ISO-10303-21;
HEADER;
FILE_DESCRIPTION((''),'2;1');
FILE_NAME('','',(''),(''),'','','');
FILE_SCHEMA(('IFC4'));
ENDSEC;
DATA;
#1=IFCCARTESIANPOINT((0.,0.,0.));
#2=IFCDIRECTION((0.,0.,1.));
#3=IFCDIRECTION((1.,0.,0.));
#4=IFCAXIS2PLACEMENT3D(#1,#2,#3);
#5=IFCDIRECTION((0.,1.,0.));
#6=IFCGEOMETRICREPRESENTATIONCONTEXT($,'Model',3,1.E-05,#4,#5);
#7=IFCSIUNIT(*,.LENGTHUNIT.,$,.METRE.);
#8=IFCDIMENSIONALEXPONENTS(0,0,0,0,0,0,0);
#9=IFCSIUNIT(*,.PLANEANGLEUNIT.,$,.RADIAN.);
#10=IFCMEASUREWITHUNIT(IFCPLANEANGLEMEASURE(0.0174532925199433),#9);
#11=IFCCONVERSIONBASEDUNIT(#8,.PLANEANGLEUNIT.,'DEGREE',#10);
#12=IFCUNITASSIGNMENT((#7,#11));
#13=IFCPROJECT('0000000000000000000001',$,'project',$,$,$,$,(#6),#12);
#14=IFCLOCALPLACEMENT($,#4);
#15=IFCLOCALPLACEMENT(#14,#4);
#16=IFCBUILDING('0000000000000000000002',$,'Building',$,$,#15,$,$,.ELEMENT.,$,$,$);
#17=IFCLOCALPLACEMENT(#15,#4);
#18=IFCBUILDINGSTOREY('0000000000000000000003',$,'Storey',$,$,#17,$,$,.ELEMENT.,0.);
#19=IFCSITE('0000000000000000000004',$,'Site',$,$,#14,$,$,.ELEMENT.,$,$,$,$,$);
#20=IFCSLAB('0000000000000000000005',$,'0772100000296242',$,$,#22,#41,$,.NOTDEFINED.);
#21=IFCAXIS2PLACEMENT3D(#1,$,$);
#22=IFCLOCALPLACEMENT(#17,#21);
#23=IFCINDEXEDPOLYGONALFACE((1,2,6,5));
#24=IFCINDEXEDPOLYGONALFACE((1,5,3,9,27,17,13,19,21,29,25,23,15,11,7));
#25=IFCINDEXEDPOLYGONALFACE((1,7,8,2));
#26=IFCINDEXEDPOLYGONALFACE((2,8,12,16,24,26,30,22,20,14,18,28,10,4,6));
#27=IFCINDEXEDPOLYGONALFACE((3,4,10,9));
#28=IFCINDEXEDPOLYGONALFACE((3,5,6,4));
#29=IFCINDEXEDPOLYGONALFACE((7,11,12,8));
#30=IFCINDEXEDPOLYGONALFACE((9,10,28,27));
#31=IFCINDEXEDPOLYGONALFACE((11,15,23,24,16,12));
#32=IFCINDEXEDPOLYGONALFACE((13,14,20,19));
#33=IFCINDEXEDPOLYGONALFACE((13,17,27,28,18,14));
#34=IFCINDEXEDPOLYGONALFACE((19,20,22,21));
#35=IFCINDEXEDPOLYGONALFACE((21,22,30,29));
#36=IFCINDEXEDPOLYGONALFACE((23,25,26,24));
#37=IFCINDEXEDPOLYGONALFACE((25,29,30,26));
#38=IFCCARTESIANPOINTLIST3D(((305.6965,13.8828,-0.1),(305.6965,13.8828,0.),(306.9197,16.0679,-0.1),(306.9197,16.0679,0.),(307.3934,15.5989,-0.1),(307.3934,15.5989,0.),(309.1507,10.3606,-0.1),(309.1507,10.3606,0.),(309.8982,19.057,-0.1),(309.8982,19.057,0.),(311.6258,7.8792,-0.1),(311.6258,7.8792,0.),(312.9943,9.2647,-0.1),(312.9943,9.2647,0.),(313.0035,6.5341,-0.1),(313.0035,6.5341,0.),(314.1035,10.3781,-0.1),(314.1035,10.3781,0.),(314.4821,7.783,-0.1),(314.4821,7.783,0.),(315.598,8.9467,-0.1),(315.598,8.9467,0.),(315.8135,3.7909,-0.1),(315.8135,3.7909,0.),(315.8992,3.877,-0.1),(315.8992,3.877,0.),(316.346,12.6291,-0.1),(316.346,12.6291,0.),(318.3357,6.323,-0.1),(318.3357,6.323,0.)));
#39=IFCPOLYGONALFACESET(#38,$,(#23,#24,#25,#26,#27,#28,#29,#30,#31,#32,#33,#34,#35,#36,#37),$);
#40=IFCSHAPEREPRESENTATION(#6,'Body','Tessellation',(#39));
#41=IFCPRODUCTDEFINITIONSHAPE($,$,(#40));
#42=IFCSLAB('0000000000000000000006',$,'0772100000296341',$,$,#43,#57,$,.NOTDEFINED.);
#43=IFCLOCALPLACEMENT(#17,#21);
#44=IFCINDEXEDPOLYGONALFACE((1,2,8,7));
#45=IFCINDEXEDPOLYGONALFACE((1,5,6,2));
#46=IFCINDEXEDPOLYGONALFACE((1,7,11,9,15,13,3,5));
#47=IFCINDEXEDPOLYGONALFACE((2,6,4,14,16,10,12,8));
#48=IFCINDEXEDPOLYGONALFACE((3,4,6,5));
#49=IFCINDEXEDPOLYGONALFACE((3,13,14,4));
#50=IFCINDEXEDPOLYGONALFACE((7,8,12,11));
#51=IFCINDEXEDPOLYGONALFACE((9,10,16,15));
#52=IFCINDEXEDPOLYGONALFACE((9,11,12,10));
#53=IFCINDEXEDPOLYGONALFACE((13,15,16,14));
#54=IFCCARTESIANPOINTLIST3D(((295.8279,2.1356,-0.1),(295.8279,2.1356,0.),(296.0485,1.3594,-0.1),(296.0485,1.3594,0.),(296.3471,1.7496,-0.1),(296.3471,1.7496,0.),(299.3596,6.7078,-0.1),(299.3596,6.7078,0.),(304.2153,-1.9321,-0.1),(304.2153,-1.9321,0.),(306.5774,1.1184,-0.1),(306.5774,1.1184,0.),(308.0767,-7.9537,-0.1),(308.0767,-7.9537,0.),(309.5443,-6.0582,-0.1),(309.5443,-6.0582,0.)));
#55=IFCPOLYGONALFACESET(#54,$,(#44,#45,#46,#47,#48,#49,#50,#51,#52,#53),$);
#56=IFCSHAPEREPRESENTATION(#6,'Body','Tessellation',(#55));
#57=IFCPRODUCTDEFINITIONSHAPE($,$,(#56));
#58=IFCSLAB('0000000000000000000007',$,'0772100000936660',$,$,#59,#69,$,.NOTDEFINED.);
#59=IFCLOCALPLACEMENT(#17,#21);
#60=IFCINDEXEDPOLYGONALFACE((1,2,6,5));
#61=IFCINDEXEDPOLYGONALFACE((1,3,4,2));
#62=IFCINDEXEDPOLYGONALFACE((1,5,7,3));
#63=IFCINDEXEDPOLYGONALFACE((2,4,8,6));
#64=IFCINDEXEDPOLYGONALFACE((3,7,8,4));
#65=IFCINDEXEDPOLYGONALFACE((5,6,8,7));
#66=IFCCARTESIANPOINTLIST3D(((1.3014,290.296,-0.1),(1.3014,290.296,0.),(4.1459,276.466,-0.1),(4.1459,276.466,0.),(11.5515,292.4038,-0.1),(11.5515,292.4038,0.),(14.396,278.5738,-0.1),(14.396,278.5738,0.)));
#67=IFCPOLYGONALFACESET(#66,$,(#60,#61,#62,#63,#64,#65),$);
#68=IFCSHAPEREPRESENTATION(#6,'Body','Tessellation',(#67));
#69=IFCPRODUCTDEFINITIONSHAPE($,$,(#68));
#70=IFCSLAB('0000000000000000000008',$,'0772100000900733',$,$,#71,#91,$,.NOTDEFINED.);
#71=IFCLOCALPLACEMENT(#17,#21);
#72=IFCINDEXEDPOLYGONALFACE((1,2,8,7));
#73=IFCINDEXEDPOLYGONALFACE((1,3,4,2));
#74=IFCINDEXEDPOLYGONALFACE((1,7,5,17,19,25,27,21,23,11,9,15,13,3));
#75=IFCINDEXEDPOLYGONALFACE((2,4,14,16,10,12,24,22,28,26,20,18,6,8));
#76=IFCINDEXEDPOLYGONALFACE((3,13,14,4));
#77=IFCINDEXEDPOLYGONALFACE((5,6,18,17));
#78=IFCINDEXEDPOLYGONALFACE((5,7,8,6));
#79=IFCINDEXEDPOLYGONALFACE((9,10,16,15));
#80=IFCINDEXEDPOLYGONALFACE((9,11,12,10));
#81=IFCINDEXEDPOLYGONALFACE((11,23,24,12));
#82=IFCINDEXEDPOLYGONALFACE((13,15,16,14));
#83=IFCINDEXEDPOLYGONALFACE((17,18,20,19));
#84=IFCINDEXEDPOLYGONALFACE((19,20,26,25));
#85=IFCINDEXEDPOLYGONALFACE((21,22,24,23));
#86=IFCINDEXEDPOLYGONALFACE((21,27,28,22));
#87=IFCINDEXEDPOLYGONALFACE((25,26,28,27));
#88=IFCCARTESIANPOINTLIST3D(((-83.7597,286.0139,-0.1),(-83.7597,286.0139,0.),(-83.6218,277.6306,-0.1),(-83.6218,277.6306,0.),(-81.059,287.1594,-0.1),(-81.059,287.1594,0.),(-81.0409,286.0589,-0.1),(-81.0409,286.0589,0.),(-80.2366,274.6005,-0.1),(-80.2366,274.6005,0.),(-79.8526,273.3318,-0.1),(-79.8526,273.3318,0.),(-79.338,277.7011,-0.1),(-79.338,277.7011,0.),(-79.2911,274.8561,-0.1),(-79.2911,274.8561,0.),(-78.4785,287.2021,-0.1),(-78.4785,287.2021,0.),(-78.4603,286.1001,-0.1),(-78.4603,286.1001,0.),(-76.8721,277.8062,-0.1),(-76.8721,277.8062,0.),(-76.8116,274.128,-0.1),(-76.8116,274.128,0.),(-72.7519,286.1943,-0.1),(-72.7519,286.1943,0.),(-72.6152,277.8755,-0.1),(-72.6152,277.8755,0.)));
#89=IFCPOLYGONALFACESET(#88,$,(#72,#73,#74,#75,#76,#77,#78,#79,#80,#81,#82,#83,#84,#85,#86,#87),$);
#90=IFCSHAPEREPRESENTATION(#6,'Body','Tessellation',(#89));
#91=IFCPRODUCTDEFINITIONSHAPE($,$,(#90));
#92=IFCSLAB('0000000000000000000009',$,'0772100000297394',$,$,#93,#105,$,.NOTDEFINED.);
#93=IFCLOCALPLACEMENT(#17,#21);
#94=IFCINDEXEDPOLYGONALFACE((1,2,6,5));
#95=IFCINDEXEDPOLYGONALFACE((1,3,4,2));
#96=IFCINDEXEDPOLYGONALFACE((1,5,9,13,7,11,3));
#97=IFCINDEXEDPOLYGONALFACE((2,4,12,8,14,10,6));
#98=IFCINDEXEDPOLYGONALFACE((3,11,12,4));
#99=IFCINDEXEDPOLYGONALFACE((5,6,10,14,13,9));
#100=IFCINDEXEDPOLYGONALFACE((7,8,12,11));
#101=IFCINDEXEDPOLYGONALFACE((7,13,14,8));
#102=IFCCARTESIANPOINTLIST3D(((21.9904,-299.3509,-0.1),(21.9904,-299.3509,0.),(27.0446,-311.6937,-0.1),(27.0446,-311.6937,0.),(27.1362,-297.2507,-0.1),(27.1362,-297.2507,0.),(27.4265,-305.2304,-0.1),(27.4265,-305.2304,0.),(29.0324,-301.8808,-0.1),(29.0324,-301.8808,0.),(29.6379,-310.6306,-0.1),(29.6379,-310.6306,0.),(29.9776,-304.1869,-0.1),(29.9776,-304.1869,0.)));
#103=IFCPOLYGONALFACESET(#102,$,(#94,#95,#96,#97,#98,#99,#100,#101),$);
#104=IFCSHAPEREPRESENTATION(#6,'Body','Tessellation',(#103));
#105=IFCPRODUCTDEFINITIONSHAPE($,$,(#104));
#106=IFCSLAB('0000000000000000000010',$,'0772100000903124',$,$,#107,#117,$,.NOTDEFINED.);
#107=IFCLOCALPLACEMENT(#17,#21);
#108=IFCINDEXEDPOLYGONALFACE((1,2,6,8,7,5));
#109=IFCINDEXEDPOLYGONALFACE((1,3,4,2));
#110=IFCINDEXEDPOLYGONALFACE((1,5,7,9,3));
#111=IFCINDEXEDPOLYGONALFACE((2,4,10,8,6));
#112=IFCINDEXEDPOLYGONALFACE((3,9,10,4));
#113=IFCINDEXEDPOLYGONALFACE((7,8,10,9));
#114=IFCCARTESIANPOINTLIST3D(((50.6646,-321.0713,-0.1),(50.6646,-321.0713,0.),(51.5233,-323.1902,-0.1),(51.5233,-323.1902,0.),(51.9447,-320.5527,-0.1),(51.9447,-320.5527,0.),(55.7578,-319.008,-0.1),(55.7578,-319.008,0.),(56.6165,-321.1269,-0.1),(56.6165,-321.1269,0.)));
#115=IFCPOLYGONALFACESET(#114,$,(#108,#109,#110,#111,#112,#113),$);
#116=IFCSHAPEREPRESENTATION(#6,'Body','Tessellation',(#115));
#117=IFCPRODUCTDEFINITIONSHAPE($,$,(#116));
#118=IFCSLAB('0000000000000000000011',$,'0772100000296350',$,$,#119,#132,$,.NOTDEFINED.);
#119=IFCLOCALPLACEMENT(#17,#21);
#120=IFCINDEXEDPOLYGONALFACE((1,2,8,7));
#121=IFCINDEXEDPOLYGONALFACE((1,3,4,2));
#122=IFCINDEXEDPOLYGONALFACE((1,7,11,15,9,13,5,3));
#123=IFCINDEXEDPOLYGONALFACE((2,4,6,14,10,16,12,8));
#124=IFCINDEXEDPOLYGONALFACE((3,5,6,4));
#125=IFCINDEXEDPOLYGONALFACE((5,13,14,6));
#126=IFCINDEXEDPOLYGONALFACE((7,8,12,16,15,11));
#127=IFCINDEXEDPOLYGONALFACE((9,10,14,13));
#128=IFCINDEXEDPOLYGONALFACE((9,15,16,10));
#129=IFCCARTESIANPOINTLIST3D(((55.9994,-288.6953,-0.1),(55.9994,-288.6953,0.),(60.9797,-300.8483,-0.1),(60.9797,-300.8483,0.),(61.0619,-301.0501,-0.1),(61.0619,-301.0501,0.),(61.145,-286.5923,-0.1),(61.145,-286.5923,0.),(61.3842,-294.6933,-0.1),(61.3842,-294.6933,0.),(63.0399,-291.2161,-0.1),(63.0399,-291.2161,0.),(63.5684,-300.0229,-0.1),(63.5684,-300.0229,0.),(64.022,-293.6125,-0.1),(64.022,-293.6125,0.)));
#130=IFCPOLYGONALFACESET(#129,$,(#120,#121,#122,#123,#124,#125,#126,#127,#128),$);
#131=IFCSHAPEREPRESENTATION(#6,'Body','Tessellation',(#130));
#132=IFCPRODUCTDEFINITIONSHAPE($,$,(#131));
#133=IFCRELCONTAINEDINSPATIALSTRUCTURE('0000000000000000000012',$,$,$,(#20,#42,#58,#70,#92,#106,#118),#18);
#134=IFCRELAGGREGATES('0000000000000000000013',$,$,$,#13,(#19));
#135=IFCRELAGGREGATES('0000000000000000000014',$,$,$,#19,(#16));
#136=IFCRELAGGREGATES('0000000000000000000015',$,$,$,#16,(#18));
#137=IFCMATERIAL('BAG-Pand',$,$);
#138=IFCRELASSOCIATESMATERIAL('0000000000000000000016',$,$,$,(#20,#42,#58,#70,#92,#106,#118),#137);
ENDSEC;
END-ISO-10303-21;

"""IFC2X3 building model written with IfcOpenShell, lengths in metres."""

from ifc_helpers import new_model, entity, si_unit, converted_unit, direction, frame, origin_with_axes, place, context, project, spatial, polyline, outline, extrude, material, element, save


model = new_model("IFC2X3")

# Units and contexts
model_context = context("Model", 3, precision=1e-05, world=origin_with_axes(), true_north=direction((0.0, 1.0, 0.0)))
ifc_project = project(units=[si_unit("LENGTHUNIT", "METRE"), converted_unit("PLANEANGLEUNIT", "DEGREE", entity("IfcPlaneAngleMeasure", 0.0174532925199433), si_unit("PLANEANGLEUNIT", "RADIAN"), dimensions=[0, 0, 0, 0, 0, 0, 0])], contexts=[model_context])

# Site, building, storey
site_placement = place(None, origin_with_axes())
site = spatial("IfcSite", under=ifc_project, at=site_placement, Name="Site", CompositionType="ELEMENT")
building_placement = place(site_placement, origin_with_axes())
building = spatial("IfcBuilding", under=site, at=building_placement, Name="Building", CompositionType="ELEMENT")
storey_placement = place(building_placement, origin_with_axes())
storey = spatial("IfcBuildingStorey", under=building, at=storey_placement, Name="Storey", CompositionType="ELEMENT", Elevation=0.0)

# Slabs
ifc_material = material(Name="BAG-Pand")
slab_1_placement = place(storey_placement, frame((0.0, 0.0, -0.1), z_axis=(0.0, 0.0, 1.0), x_axis=(1.0, 0.0, 0.0)))
element("IfcSlab", 1, at=slab_1_placement, inside=storey, material=ifc_material, Name="0772100000296242", PredefinedType="NOTDEFINED", context=model_context, shape_type="SweptSolid", body=[
    extrude(outline(polyline([(313.0035, 6.5341), (311.6258, 7.8792), (309.1507, 10.3606), (305.6965, 13.8828), (307.3934, 15.5989), (306.9197, 16.0679), (309.8982, 19.057), (316.346, 12.6291), (314.1035, 10.3781), (312.9943, 9.2647), (314.4821, 7.783), (315.598, 8.9467), (318.3357, 6.323), (315.8992, 3.877), (315.8135, 3.7909), (313.0035, 6.5341)])), origin_with_axes(), (0.0, 0.0, 1.0), 0.1),
])
slab_2_placement = place(storey_placement, frame((0.0, 0.0, -0.1), z_axis=(0.0, 0.0, 1.0), x_axis=(1.0, 0.0, 0.0)))
element("IfcSlab", 2, at=slab_2_placement, inside=storey, material=ifc_material, Name="0772100000296341", PredefinedType="NOTDEFINED", context=model_context, shape_type="SweptSolid", body=[
    extrude(outline(polyline([(296.3471, 1.7496), (295.8279, 2.1356), (299.3596, 6.7078), (306.5774, 1.1184), (304.2153, -1.9321), (309.5443, -6.0582), (308.0767, -7.9537), (296.0485, 1.3594), (296.3471, 1.7496)])), origin_with_axes(), (0.0, 0.0, 1.0), 0.1),
])
slab_3_placement = place(storey_placement, frame((0.0, 0.0, -0.1), z_axis=(0.0, 0.0, 1.0), x_axis=(1.0, 0.0, 0.0)))
element("IfcSlab", 3, at=slab_3_placement, inside=storey, material=ifc_material, Name="0772100000936660", PredefinedType="NOTDEFINED", context=model_context, shape_type="SweptSolid", body=[
    extrude(outline(polyline([(11.5515, 292.4038), (14.396, 278.5738), (4.1459, 276.466), (1.3014, 290.296), (11.5515, 292.4038)])), origin_with_axes(), (0.0, 0.0, 1.0), 0.1),
])
slab_4_placement = place(storey_placement, frame((0.0, 0.0, -0.1), z_axis=(0.0, 0.0, 1.0), x_axis=(1.0, 0.0, 0.0)))
element("IfcSlab", 4, at=slab_4_placement, inside=storey, material=ifc_material, Name="0772100000900733", PredefinedType="NOTDEFINED", context=model_context, shape_type="SweptSolid", body=[
    extrude(outline(polyline([(-80.2366, 274.6005), (-79.2911, 274.8561), (-79.338, 277.7011), (-83.6218, 277.6306), (-83.7597, 286.0139), (-81.0409, 286.0589), (-81.059, 287.1594), (-78.4785, 287.2021), (-78.4603, 286.1001), (-72.7519, 286.1943), (-72.6152, 277.8755), (-76.8721, 277.8062), (-76.8116, 274.128), (-79.8526, 273.3318), (-80.2366, 274.6005)])), origin_with_axes(), (0.0, 0.0, 1.0), 0.1),
])
slab_5_placement = place(storey_placement, frame((0.0, 0.0, -0.1), z_axis=(0.0, 0.0, 1.0), x_axis=(1.0, 0.0, 0.0)))
element("IfcSlab", 5, at=slab_5_placement, inside=storey, material=ifc_material, Name="0772100000297394", PredefinedType="NOTDEFINED", context=model_context, shape_type="SweptSolid", body=[
    extrude(outline(polyline([(27.1362, -297.2507), (29.0324, -301.8808), (29.9776, -304.1869), (27.4265, -305.2304), (29.6379, -310.6306), (27.0446, -311.6937), (21.9904, -299.3509), (27.1362, -297.2507)])), origin_with_axes(), (0.0, 0.0, 1.0), 0.1),
])
slab_6_placement = place(storey_placement, frame((0.0, 0.0, -0.1), z_axis=(0.0, 0.0, 1.0), x_axis=(1.0, 0.0, 0.0)))
element("IfcSlab", 6, at=slab_6_placement, inside=storey, material=ifc_material, Name="0772100000903124", PredefinedType="NOTDEFINED", context=model_context, shape_type="SweptSolid", body=[
    extrude(outline(polyline([(50.6646, -321.0713), (51.9447, -320.5527), (55.7578, -319.008), (56.6165, -321.1269), (51.5233, -323.1902), (50.6646, -321.0713)])), origin_with_axes(), (0.0, 0.0, 1.0), 0.1),
])
slab_7_placement = place(storey_placement, frame((0.0, 0.0, -0.1), z_axis=(0.0, 0.0, 1.0), x_axis=(1.0, 0.0, 0.0)))
element("IfcSlab", 7, at=slab_7_placement, inside=storey, material=ifc_material, Name="0772100000296350", PredefinedType="NOTDEFINED", context=model_context, shape_type="SweptSolid", body=[
    extrude(outline(polyline([(61.0619, -301.0501), (60.9797, -300.8483), (55.9994, -288.6953), (61.145, -286.5923), (63.0399, -291.2161), (64.022, -293.6125), (61.3842, -294.6933), (63.5684, -300.0229), (61.0619, -301.0501)])), origin_with_axes(), (0.0, 0.0, 1.0), 0.1),
])

save(model, "model.ifc")
